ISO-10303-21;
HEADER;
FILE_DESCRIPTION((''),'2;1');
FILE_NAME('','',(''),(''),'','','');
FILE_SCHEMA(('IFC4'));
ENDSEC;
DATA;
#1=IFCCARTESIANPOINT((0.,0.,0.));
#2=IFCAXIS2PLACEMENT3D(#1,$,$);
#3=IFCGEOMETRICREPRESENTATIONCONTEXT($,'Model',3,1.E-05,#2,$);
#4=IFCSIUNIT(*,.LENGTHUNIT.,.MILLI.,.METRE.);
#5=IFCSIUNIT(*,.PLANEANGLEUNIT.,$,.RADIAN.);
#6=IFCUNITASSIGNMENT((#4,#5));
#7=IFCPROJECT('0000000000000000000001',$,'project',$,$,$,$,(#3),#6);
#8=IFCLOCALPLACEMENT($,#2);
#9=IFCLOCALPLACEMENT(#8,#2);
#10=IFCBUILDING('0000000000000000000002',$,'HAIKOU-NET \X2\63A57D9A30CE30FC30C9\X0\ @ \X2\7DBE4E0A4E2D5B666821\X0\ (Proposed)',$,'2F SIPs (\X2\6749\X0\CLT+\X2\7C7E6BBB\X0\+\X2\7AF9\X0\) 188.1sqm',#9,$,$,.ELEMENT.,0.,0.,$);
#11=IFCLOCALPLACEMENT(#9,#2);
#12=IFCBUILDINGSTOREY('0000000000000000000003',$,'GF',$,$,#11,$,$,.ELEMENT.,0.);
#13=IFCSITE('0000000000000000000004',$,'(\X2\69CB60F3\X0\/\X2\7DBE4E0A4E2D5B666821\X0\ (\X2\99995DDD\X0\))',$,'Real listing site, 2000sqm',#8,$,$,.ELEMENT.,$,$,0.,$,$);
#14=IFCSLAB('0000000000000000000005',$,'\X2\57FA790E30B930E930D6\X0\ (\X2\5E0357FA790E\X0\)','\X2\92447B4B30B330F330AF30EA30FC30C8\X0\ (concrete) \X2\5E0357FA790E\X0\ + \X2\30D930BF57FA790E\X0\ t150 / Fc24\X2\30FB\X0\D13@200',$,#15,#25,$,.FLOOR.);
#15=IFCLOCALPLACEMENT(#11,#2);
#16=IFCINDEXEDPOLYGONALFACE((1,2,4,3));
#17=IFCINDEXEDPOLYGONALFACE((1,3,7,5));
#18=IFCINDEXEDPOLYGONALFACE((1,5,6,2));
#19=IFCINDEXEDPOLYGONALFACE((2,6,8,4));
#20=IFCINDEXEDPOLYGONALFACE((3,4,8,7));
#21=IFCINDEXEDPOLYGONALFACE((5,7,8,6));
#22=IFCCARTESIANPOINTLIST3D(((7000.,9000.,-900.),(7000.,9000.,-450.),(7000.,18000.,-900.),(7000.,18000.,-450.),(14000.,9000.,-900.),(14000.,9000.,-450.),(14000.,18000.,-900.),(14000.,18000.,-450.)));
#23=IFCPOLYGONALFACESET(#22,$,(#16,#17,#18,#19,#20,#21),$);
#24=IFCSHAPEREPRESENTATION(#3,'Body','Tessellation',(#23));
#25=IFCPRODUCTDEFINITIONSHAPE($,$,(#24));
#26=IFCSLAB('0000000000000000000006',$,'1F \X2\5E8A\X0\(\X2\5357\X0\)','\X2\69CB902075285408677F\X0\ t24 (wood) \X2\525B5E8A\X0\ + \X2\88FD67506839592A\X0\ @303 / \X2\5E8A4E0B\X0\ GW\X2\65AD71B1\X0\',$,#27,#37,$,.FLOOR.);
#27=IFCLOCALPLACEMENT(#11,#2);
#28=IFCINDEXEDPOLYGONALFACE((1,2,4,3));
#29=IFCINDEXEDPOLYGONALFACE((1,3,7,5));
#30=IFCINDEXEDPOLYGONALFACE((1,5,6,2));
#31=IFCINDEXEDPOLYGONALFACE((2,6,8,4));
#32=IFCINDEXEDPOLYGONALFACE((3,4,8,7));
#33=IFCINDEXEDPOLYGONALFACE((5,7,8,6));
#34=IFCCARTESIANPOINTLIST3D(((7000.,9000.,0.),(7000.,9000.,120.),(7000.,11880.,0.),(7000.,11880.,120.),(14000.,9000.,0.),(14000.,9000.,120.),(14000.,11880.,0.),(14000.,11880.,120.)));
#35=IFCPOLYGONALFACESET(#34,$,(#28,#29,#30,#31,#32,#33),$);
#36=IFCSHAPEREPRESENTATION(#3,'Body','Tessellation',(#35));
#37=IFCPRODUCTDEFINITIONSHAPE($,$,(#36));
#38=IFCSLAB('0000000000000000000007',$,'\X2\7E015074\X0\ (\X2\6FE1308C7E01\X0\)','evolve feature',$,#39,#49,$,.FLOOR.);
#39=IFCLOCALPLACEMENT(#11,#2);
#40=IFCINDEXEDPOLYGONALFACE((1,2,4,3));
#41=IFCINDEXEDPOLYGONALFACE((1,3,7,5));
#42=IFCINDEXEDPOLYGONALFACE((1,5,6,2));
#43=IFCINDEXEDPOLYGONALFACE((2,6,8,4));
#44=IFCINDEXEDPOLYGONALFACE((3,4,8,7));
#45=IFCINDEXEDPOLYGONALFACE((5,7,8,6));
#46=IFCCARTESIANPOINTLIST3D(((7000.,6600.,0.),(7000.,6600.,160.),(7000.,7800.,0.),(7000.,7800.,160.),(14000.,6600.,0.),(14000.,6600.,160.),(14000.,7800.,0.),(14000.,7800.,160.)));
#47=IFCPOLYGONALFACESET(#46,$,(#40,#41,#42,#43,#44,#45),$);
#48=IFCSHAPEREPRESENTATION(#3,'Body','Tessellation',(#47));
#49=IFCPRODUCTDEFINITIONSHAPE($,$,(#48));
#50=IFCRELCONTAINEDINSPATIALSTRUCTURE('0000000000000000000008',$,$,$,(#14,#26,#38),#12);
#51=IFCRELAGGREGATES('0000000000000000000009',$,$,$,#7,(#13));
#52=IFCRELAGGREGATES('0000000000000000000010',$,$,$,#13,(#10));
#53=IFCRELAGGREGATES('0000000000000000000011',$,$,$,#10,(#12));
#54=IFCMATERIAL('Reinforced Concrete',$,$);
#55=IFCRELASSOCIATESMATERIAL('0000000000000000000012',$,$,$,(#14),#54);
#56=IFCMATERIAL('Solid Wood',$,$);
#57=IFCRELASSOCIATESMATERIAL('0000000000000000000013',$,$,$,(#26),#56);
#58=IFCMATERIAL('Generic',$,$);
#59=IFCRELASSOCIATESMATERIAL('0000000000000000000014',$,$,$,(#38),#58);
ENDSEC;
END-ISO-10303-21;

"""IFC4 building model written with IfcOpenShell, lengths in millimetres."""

from ifc_helpers import new_model, si_unit, frame, frame_2d, origin, place, context, project, spatial, rectangle, extrude, material, element, save


model = new_model("IFC4")

# Units and contexts
model_context = context("Model", 3, precision=1e-05, world=origin())
ifc_project = project(units=[si_unit("LENGTHUNIT", "METRE", prefix="MILLI"), si_unit("PLANEANGLEUNIT", "RADIAN")], contexts=[model_context])

# Site, building, storey
site_placement = place(None, origin())
site = spatial("IfcSite", under=ifc_project, at=site_placement, Name="(構想/綾上中学校 (香川))", ObjectType="Real listing site, 2000sqm", CompositionType="ELEMENT", RefElevation=0.0)
building_placement = place(site_placement, origin())
building = spatial("IfcBuilding", under=site, at=building_placement, Name="HAIKOU-NET 接続ノード @ 綾上中学校 (Proposed)", ObjectType="2F SIPs (杉CLT+籾殻+竹) 188.1sqm", CompositionType="ELEMENT", ElevationOfRefHeight=0.0, ElevationOfTerrain=0.0)
storey_placement = place(building_placement, origin())
storey = spatial("IfcBuildingStorey", under=building, at=storey_placement, Name="GF", CompositionType="ELEMENT", Elevation=0.0)

# Slabs
ifc_material_1 = material(Name="Reinforced Concrete")
slab_1_placement = place(storey_placement, frame((3500.0, 4500.0, -450.0)))
element("IfcSlab", 1, at=slab_1_placement, inside=storey, material=ifc_material_1, Name="基礎スラブ (布基礎)", Description="鉄筋コンクリート (concrete) 布基礎 + ベタ基礎 t150 / Fc24・D13@200", PredefinedType="FLOOR", context=model_context, shape_type="SweptSolid", body=[
    extrude(rectangle(XDim=7000.0, YDim=9000.0, at=frame_2d((3500.0, 4500.0))), frame((3500.0, 4500.0, -450.0)), (0.0, 0.0, 1.0), 450.0),
])
ifc_material_2 = material(Name="Solid Wood")
slab_2_placement = place(storey_placement, frame((3500.0, 4500.0, 0.0)))
element("IfcSlab", 2, at=slab_2_placement, inside=storey, material=ifc_material_2, Name="1F 床(南)", Description="構造用合板 t24 (wood) 剛床 + 製材根太 @303 / 床下 GW断熱", PredefinedType="FLOOR", context=model_context, shape_type="SweptSolid", body=[
    extrude(rectangle(XDim=7000.0, YDim=2880.0, at=frame_2d((3500.0, 1440.0))), frame((3500.0, 4500.0, 0.0)), (0.0, 0.0, 1.0), 120.0),
])
ifc_material_3 = material(Name="Generic")
slab_3_placement = place(storey_placement, frame((3500.0, 3300.0, 0.0)))
element("IfcSlab", 3, at=slab_3_placement, inside=storey, material=ifc_material_3, Name="縁側 (濡れ縁)", Description="evolve feature", PredefinedType="FLOOR", context=model_context, shape_type="SweptSolid", body=[
    extrude(rectangle(XDim=7000.0, YDim=1200.0, at=frame_2d((3500.0, 600.0))), frame((3500.0, 3300.0, 0.0)), (0.0, 0.0, 1.0), 160.0),
])

save(model, "model.ifc")
